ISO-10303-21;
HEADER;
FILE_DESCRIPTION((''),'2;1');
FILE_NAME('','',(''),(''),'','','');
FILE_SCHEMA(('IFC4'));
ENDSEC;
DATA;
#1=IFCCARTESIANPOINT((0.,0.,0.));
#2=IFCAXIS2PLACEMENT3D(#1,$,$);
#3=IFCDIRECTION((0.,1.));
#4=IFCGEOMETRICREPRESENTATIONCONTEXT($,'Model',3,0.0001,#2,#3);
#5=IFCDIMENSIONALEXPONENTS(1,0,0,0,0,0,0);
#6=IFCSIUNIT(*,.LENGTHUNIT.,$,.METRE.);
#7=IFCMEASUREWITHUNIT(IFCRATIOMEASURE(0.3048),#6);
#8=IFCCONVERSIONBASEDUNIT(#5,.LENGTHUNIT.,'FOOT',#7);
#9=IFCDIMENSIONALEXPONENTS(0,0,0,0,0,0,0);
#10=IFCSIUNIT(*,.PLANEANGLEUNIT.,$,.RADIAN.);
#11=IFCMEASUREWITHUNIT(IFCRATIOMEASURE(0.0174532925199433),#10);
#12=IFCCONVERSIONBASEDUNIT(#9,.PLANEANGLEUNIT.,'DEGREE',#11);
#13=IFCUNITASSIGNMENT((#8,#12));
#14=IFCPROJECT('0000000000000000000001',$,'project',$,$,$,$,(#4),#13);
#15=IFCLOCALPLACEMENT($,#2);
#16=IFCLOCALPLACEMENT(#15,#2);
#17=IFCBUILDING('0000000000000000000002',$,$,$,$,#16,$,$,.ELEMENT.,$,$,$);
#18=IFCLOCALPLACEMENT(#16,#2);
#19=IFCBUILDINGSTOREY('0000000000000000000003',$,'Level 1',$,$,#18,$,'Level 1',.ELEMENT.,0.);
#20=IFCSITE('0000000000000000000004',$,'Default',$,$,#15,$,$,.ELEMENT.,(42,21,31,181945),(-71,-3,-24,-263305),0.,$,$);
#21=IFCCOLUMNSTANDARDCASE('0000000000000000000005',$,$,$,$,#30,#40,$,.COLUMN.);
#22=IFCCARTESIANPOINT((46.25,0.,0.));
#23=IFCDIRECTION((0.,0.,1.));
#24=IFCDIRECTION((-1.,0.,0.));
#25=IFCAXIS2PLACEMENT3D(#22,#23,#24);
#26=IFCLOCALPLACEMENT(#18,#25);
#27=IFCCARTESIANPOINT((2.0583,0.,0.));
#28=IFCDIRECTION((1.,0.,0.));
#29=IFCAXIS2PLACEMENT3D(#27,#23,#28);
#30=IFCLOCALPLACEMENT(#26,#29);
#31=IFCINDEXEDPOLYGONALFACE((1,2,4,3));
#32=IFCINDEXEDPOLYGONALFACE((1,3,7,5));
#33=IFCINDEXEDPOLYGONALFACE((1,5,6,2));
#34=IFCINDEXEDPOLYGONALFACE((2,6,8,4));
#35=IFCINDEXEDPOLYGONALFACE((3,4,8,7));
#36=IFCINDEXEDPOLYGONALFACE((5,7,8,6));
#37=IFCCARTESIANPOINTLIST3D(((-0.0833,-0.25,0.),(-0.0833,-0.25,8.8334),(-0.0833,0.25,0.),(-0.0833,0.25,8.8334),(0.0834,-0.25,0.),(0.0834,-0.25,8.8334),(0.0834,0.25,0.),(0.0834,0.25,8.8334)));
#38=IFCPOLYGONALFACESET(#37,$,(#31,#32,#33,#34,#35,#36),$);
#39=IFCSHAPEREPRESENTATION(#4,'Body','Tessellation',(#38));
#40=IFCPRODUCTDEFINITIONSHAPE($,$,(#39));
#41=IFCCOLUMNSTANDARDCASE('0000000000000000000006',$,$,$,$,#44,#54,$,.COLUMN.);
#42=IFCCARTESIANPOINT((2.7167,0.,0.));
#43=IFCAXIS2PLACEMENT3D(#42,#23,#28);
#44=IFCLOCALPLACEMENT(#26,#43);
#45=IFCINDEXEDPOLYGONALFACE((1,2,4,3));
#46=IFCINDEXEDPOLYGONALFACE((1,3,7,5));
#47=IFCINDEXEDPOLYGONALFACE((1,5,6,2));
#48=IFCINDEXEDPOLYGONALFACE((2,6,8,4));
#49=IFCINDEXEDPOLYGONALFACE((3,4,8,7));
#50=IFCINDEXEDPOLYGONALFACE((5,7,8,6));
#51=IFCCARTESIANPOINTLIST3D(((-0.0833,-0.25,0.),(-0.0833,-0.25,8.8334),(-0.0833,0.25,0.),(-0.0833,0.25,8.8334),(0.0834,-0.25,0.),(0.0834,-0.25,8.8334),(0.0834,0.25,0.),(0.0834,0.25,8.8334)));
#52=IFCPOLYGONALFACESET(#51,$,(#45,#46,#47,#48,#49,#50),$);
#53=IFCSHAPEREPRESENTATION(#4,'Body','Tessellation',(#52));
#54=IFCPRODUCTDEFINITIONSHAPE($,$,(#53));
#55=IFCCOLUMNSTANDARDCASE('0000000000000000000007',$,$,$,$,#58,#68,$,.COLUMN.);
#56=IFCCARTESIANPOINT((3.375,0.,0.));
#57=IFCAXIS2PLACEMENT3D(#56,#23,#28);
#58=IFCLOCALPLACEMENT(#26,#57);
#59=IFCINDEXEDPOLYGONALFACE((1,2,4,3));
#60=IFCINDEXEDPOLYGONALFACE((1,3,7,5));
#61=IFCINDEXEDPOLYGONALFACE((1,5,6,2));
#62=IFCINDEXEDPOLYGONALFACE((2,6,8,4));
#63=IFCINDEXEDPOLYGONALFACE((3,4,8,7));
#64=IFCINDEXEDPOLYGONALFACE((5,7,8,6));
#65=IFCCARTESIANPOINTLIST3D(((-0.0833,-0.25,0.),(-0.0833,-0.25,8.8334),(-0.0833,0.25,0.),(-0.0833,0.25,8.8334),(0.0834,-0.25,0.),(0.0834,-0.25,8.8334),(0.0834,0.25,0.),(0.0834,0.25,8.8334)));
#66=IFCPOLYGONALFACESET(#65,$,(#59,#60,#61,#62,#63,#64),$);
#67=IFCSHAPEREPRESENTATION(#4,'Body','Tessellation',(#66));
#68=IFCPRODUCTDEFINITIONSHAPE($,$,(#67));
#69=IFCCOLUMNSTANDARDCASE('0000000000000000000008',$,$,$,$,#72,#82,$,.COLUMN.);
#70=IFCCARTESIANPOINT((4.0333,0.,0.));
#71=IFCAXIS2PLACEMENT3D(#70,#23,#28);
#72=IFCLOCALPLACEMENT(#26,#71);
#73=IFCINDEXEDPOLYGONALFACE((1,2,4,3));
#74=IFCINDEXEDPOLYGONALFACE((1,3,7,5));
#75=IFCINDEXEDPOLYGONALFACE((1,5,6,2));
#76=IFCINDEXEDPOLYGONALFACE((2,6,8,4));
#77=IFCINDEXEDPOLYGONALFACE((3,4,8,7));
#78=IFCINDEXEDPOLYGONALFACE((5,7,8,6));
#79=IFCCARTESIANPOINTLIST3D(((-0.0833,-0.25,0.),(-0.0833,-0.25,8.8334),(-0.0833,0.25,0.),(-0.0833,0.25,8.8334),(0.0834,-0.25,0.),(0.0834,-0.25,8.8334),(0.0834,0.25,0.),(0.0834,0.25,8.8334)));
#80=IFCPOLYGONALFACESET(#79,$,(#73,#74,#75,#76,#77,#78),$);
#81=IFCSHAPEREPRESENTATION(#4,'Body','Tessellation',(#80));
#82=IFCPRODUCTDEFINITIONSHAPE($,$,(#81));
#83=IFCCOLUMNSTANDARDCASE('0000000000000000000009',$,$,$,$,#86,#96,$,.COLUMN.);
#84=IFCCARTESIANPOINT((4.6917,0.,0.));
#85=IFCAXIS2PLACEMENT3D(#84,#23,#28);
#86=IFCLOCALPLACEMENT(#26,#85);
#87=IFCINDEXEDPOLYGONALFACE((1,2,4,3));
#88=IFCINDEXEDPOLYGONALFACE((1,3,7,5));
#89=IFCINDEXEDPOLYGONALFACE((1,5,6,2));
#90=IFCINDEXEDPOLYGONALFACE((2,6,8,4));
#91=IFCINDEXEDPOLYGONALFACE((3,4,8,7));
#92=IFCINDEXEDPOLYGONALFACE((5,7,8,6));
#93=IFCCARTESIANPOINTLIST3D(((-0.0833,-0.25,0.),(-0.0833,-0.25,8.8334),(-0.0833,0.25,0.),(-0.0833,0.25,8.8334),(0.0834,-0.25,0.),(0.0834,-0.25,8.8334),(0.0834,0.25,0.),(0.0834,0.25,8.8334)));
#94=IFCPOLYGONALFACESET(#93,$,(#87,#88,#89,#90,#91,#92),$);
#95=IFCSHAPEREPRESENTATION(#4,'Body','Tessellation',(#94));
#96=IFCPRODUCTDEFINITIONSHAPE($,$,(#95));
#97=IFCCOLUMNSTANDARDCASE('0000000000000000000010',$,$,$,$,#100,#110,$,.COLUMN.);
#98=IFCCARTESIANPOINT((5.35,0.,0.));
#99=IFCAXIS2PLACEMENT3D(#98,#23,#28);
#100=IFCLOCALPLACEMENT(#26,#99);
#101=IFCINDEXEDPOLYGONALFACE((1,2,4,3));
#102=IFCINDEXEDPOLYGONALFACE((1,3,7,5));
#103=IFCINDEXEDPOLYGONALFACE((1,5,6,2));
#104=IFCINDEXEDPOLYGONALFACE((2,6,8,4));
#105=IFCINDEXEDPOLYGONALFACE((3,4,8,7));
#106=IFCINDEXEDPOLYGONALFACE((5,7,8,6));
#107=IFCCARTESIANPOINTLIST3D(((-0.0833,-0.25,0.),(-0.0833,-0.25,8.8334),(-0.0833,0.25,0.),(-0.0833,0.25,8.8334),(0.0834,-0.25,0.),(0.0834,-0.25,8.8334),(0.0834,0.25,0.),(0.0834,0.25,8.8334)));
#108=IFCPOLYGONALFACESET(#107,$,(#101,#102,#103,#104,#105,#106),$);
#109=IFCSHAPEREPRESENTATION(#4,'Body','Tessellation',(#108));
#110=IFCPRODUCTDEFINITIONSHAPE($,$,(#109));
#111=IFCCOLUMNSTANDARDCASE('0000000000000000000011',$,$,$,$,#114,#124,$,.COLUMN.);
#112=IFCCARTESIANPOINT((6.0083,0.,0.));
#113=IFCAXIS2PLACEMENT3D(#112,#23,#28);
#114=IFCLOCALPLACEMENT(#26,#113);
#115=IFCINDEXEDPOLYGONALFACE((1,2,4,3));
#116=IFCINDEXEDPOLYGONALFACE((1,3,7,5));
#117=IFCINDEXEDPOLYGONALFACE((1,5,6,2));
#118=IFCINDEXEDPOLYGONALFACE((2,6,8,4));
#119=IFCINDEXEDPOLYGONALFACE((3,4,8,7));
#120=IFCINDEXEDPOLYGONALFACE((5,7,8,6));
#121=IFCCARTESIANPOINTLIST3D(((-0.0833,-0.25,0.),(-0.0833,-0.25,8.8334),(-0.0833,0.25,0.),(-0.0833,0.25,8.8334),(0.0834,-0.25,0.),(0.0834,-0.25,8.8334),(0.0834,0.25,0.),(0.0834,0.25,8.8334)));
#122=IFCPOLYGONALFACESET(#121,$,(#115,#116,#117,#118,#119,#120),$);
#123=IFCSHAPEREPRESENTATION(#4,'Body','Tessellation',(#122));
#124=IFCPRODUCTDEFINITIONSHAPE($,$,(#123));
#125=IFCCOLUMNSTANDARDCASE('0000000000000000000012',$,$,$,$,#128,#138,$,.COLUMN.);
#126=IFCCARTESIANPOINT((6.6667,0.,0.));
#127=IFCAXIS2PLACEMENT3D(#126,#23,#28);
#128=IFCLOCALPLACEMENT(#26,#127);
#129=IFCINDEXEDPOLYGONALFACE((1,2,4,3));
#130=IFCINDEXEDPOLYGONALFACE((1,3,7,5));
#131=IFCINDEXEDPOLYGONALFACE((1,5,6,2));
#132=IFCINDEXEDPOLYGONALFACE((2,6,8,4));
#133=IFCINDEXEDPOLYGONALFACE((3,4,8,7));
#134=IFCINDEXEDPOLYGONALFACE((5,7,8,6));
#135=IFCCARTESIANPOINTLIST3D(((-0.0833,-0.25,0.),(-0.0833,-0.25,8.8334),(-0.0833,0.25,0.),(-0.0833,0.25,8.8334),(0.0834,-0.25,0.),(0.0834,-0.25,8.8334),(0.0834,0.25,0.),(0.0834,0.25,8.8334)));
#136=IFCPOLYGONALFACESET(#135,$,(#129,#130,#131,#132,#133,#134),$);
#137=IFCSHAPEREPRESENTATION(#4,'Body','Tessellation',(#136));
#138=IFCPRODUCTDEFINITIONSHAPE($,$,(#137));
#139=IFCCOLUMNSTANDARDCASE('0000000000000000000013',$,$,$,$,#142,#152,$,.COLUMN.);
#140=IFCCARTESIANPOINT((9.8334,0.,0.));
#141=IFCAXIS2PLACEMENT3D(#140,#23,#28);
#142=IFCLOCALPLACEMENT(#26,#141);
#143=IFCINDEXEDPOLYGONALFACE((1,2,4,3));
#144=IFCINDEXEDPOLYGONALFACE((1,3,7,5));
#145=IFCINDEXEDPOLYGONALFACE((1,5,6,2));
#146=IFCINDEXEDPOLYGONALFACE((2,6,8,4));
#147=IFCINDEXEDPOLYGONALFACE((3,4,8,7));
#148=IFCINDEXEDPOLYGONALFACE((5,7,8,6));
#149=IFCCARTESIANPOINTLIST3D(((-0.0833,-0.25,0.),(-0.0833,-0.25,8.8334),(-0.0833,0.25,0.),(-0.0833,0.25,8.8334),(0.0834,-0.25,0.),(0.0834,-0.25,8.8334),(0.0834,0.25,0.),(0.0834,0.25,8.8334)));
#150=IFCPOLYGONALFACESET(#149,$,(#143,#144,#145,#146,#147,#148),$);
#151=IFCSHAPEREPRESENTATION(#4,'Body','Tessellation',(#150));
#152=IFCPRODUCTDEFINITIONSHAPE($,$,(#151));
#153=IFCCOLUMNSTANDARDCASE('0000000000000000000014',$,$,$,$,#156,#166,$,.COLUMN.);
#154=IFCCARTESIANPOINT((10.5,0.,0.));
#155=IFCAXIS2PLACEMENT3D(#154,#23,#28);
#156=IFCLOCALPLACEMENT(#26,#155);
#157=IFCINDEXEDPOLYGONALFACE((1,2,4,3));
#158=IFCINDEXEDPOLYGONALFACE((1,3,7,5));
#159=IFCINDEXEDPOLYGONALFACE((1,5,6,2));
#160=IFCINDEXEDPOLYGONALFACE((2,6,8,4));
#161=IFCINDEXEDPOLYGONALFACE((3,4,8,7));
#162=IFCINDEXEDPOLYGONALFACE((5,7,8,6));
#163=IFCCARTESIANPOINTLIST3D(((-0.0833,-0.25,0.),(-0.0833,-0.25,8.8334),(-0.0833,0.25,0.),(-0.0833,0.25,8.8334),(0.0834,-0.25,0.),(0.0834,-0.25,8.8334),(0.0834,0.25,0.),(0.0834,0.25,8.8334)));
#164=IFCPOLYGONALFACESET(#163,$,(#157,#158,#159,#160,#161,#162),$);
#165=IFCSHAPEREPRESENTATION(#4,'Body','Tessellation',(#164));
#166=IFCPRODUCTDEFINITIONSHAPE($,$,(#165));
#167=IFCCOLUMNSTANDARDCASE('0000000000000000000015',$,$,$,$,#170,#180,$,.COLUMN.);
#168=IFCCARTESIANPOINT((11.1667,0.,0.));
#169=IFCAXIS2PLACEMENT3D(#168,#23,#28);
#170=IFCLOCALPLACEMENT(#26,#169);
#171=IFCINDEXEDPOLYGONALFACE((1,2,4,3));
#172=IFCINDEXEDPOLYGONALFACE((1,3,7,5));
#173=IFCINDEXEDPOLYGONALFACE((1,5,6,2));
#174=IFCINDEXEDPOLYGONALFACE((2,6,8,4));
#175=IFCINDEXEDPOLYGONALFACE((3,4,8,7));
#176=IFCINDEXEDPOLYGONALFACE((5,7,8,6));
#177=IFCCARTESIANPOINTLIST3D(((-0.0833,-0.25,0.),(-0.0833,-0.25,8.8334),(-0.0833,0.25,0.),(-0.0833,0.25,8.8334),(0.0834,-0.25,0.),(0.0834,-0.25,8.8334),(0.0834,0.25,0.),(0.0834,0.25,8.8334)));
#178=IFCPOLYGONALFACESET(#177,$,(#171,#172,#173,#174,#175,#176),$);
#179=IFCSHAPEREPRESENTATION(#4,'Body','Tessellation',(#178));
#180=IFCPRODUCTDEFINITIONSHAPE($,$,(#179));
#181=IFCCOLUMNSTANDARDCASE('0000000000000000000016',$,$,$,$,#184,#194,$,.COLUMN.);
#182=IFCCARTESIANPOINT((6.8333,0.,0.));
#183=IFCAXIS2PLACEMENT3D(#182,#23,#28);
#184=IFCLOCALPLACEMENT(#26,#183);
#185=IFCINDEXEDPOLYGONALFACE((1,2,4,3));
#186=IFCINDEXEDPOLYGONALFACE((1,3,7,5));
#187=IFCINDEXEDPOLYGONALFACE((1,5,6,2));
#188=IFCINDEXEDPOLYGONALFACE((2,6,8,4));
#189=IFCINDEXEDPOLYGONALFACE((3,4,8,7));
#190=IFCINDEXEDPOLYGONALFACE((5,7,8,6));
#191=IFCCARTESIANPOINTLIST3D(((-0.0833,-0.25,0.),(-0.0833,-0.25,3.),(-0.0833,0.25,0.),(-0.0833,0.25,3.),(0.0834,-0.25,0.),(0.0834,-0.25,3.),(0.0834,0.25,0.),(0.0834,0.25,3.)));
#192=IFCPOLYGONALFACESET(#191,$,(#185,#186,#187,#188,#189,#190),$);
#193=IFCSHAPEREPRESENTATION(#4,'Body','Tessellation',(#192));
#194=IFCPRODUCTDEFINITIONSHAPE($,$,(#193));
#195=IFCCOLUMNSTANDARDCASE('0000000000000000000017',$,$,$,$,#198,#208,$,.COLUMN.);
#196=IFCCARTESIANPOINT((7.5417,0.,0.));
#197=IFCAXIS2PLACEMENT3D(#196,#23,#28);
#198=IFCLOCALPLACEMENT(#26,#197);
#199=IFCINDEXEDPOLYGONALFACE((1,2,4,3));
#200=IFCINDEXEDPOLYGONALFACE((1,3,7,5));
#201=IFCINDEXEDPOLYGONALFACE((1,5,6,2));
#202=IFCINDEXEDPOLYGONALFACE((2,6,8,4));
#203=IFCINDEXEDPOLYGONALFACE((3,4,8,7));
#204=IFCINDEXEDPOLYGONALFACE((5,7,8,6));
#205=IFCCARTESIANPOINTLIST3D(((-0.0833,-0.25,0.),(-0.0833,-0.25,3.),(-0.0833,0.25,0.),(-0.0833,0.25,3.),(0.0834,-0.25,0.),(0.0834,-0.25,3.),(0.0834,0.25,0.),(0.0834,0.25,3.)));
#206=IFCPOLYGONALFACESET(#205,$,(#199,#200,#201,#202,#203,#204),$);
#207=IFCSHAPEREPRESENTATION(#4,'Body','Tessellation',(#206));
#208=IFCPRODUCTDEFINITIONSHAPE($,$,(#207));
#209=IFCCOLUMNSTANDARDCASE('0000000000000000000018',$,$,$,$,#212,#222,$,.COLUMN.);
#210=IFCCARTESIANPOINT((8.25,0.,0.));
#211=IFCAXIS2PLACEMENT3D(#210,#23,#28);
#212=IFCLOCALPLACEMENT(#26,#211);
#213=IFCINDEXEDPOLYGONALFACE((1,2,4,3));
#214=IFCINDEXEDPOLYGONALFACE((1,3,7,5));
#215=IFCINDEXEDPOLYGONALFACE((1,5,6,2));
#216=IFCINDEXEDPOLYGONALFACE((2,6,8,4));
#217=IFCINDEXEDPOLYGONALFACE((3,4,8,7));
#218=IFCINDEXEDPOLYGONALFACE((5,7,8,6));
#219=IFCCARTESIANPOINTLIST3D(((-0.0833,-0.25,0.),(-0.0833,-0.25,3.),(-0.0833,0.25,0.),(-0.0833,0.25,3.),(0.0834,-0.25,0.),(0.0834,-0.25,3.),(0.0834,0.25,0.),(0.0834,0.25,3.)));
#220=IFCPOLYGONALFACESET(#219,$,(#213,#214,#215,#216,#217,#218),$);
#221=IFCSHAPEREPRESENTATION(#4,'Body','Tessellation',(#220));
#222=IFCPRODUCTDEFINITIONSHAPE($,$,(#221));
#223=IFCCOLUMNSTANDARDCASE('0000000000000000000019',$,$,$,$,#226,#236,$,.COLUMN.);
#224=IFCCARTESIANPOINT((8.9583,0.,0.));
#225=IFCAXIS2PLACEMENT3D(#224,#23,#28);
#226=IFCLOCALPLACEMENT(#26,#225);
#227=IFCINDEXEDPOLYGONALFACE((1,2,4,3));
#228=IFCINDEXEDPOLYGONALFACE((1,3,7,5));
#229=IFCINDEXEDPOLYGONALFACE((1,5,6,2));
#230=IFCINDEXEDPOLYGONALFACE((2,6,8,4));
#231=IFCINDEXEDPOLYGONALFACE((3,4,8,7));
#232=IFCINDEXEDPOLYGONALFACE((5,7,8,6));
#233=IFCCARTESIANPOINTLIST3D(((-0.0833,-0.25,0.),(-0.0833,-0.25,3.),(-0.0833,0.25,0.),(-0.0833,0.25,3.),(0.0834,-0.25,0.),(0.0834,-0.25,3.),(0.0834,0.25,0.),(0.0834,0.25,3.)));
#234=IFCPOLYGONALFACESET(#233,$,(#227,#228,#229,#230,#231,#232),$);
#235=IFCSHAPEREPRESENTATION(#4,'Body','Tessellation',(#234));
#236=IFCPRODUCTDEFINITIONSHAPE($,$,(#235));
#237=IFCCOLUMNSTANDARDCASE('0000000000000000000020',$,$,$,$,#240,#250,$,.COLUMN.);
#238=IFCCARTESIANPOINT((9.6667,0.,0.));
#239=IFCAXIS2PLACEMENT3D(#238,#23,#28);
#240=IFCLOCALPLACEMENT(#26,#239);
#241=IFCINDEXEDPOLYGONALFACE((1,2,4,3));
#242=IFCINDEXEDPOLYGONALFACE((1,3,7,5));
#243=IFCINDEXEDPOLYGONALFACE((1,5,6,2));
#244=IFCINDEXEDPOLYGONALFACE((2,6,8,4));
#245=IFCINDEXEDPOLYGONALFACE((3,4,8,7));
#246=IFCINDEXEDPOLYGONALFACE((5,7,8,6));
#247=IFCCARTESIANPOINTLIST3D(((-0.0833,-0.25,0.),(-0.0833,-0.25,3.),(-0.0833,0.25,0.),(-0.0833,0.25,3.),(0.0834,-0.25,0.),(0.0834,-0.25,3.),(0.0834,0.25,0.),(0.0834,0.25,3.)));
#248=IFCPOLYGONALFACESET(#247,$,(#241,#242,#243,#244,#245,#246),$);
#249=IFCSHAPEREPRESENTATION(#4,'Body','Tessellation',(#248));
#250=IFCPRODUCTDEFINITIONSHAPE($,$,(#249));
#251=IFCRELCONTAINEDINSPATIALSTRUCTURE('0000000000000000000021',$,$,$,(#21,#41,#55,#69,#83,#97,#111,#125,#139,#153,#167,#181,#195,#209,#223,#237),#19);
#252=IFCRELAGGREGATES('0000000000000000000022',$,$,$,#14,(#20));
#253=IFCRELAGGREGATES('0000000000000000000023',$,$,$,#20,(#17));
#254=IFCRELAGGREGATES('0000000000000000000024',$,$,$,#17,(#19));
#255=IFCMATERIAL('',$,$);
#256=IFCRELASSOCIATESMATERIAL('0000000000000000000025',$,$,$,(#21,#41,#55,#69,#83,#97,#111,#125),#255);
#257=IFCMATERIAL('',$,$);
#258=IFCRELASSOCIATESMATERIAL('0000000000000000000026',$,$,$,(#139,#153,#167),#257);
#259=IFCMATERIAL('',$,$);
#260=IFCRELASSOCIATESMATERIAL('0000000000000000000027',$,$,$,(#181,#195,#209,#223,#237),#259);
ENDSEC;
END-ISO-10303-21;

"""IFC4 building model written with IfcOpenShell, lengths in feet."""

from ifc_helpers import new_model, entity, si_unit, converted_unit, direction, frame, origin, place, context, project, spatial, rectangle, extrude, material, element, save


model = new_model("IFC4")

# Units and contexts
model_context = context("Model", 3, precision=0.0001, world=origin(), true_north=direction((0.0, 1.0)))
ifc_project = project(units=[converted_unit("LENGTHUNIT", "FOOT", entity("IfcRatioMeasure", 0.3048), si_unit("LENGTHUNIT", "METRE"), dimensions=[1, 0, 0, 0, 0, 0, 0]), converted_unit("PLANEANGLEUNIT", "DEGREE", entity("IfcRatioMeasure", 0.0174532925199433), si_unit("PLANEANGLEUNIT", "RADIAN"), dimensions=[0, 0, 0, 0, 0, 0, 0])], contexts=[model_context])

# Site, building, storey
site_placement = place(None, origin())
site = spatial("IfcSite", under=ifc_project, at=site_placement, Name="Default", CompositionType="ELEMENT", RefLatitude=(42, 21, 31, 181945), RefLongitude=(-71, -3, -24, -263305), RefElevation=0.0)
building_placement = place(site_placement, origin())
building = spatial("IfcBuilding", under=site, at=building_placement, CompositionType="ELEMENT")
storey_placement = place(building_placement, origin())
storey = spatial("IfcBuildingStorey", under=building, at=storey_placement, Name="Level 1", LongName="Level 1", CompositionType="ELEMENT", Elevation=0.0)

# Columns
ifc_material_1 = material(Name="")
placement_1 = place(storey_placement, frame((46.25, 0.0, 0.0), z_axis=(0.0, 0.0, 1.0), x_axis=(-1.0, 0.0, 0.0)))
for number, where, z_axis, x_axis in (
    (1, (2.0583, 0.0, 0.0), (0.0, 0.0, 1.0), (1.0, 0.0, 0.0)),
    (2, (2.7167, 0.0, 0.0), (0.0, 0.0, 1.0), (1.0, 0.0, 0.0)),
    (3, (3.375, 0.0, 0.0), (0.0, 0.0, 1.0), (1.0, 0.0, 0.0)),
    (4, (4.0333, 0.0, 0.0), (0.0, 0.0, 1.0), (1.0, 0.0, 0.0)),
    (5, (4.6917, 0.0, 0.0), (0.0, 0.0, 1.0), (1.0, 0.0, 0.0)),
    (6, (5.35, 0.0, 0.0), (0.0, 0.0, 1.0), (1.0, 0.0, 0.0)),
    (7, (6.0083, 0.0, 0.0), (0.0, 0.0, 1.0), (1.0, 0.0, 0.0)),
    (8, (6.6667, 0.0, 0.0), (0.0, 0.0, 1.0), (1.0, 0.0, 0.0)),
):
    element("IfcColumnStandardCase", number, at=place(placement_1, frame(where, z_axis=z_axis, x_axis=x_axis)), inside=storey, material=ifc_material_1, PredefinedType="COLUMN", context=model_context, shape_type="SweptSolid", body=[
        extrude(rectangle(XDim=0.1667, YDim=0.5), origin(), (0.0, 0.0, 1.0), 8.8334),
    ])
ifc_material_2 = material(Name="")
for number, where, z_axis, x_axis in (
    (9, (9.8334, 0.0, 0.0), (0.0, 0.0, 1.0), (1.0, 0.0, 0.0)),
    (10, (10.5, 0.0, 0.0), (0.0, 0.0, 1.0), (1.0, 0.0, 0.0)),
    (11, (11.1667, 0.0, 0.0), (0.0, 0.0, 1.0), (1.0, 0.0, 0.0)),
):
    element("IfcColumnStandardCase", number, at=place(placement_1, frame(where, z_axis=z_axis, x_axis=x_axis)), inside=storey, material=ifc_material_2, PredefinedType="COLUMN", context=model_context, shape_type="SweptSolid", body=[
        extrude(rectangle(XDim=0.1667, YDim=0.5), origin(), (0.0, 0.0, 1.0), 8.8334),
    ])
ifc_material_3 = material(Name="")
for number, where, z_axis, x_axis in (
    (12, (6.8333, 0.0, 0.0), (0.0, 0.0, 1.0), (1.0, 0.0, 0.0)),
    (13, (7.5417, 0.0, 0.0), (0.0, 0.0, 1.0), (1.0, 0.0, 0.0)),
    (14, (8.25, 0.0, 0.0), (0.0, 0.0, 1.0), (1.0, 0.0, 0.0)),
    (15, (8.9583, 0.0, 0.0), (0.0, 0.0, 1.0), (1.0, 0.0, 0.0)),
    (16, (9.6667, 0.0, 0.0), (0.0, 0.0, 1.0), (1.0, 0.0, 0.0)),
):
    element("IfcColumnStandardCase", number, at=place(placement_1, frame(where, z_axis=z_axis, x_axis=x_axis)), inside=storey, material=ifc_material_3, PredefinedType="COLUMN", context=model_context, shape_type="SweptSolid", body=[
        extrude(rectangle(XDim=0.1667, YDim=0.5), origin(), (0.0, 0.0, 1.0), 3.0),
    ])

save(model, "model.ifc")
